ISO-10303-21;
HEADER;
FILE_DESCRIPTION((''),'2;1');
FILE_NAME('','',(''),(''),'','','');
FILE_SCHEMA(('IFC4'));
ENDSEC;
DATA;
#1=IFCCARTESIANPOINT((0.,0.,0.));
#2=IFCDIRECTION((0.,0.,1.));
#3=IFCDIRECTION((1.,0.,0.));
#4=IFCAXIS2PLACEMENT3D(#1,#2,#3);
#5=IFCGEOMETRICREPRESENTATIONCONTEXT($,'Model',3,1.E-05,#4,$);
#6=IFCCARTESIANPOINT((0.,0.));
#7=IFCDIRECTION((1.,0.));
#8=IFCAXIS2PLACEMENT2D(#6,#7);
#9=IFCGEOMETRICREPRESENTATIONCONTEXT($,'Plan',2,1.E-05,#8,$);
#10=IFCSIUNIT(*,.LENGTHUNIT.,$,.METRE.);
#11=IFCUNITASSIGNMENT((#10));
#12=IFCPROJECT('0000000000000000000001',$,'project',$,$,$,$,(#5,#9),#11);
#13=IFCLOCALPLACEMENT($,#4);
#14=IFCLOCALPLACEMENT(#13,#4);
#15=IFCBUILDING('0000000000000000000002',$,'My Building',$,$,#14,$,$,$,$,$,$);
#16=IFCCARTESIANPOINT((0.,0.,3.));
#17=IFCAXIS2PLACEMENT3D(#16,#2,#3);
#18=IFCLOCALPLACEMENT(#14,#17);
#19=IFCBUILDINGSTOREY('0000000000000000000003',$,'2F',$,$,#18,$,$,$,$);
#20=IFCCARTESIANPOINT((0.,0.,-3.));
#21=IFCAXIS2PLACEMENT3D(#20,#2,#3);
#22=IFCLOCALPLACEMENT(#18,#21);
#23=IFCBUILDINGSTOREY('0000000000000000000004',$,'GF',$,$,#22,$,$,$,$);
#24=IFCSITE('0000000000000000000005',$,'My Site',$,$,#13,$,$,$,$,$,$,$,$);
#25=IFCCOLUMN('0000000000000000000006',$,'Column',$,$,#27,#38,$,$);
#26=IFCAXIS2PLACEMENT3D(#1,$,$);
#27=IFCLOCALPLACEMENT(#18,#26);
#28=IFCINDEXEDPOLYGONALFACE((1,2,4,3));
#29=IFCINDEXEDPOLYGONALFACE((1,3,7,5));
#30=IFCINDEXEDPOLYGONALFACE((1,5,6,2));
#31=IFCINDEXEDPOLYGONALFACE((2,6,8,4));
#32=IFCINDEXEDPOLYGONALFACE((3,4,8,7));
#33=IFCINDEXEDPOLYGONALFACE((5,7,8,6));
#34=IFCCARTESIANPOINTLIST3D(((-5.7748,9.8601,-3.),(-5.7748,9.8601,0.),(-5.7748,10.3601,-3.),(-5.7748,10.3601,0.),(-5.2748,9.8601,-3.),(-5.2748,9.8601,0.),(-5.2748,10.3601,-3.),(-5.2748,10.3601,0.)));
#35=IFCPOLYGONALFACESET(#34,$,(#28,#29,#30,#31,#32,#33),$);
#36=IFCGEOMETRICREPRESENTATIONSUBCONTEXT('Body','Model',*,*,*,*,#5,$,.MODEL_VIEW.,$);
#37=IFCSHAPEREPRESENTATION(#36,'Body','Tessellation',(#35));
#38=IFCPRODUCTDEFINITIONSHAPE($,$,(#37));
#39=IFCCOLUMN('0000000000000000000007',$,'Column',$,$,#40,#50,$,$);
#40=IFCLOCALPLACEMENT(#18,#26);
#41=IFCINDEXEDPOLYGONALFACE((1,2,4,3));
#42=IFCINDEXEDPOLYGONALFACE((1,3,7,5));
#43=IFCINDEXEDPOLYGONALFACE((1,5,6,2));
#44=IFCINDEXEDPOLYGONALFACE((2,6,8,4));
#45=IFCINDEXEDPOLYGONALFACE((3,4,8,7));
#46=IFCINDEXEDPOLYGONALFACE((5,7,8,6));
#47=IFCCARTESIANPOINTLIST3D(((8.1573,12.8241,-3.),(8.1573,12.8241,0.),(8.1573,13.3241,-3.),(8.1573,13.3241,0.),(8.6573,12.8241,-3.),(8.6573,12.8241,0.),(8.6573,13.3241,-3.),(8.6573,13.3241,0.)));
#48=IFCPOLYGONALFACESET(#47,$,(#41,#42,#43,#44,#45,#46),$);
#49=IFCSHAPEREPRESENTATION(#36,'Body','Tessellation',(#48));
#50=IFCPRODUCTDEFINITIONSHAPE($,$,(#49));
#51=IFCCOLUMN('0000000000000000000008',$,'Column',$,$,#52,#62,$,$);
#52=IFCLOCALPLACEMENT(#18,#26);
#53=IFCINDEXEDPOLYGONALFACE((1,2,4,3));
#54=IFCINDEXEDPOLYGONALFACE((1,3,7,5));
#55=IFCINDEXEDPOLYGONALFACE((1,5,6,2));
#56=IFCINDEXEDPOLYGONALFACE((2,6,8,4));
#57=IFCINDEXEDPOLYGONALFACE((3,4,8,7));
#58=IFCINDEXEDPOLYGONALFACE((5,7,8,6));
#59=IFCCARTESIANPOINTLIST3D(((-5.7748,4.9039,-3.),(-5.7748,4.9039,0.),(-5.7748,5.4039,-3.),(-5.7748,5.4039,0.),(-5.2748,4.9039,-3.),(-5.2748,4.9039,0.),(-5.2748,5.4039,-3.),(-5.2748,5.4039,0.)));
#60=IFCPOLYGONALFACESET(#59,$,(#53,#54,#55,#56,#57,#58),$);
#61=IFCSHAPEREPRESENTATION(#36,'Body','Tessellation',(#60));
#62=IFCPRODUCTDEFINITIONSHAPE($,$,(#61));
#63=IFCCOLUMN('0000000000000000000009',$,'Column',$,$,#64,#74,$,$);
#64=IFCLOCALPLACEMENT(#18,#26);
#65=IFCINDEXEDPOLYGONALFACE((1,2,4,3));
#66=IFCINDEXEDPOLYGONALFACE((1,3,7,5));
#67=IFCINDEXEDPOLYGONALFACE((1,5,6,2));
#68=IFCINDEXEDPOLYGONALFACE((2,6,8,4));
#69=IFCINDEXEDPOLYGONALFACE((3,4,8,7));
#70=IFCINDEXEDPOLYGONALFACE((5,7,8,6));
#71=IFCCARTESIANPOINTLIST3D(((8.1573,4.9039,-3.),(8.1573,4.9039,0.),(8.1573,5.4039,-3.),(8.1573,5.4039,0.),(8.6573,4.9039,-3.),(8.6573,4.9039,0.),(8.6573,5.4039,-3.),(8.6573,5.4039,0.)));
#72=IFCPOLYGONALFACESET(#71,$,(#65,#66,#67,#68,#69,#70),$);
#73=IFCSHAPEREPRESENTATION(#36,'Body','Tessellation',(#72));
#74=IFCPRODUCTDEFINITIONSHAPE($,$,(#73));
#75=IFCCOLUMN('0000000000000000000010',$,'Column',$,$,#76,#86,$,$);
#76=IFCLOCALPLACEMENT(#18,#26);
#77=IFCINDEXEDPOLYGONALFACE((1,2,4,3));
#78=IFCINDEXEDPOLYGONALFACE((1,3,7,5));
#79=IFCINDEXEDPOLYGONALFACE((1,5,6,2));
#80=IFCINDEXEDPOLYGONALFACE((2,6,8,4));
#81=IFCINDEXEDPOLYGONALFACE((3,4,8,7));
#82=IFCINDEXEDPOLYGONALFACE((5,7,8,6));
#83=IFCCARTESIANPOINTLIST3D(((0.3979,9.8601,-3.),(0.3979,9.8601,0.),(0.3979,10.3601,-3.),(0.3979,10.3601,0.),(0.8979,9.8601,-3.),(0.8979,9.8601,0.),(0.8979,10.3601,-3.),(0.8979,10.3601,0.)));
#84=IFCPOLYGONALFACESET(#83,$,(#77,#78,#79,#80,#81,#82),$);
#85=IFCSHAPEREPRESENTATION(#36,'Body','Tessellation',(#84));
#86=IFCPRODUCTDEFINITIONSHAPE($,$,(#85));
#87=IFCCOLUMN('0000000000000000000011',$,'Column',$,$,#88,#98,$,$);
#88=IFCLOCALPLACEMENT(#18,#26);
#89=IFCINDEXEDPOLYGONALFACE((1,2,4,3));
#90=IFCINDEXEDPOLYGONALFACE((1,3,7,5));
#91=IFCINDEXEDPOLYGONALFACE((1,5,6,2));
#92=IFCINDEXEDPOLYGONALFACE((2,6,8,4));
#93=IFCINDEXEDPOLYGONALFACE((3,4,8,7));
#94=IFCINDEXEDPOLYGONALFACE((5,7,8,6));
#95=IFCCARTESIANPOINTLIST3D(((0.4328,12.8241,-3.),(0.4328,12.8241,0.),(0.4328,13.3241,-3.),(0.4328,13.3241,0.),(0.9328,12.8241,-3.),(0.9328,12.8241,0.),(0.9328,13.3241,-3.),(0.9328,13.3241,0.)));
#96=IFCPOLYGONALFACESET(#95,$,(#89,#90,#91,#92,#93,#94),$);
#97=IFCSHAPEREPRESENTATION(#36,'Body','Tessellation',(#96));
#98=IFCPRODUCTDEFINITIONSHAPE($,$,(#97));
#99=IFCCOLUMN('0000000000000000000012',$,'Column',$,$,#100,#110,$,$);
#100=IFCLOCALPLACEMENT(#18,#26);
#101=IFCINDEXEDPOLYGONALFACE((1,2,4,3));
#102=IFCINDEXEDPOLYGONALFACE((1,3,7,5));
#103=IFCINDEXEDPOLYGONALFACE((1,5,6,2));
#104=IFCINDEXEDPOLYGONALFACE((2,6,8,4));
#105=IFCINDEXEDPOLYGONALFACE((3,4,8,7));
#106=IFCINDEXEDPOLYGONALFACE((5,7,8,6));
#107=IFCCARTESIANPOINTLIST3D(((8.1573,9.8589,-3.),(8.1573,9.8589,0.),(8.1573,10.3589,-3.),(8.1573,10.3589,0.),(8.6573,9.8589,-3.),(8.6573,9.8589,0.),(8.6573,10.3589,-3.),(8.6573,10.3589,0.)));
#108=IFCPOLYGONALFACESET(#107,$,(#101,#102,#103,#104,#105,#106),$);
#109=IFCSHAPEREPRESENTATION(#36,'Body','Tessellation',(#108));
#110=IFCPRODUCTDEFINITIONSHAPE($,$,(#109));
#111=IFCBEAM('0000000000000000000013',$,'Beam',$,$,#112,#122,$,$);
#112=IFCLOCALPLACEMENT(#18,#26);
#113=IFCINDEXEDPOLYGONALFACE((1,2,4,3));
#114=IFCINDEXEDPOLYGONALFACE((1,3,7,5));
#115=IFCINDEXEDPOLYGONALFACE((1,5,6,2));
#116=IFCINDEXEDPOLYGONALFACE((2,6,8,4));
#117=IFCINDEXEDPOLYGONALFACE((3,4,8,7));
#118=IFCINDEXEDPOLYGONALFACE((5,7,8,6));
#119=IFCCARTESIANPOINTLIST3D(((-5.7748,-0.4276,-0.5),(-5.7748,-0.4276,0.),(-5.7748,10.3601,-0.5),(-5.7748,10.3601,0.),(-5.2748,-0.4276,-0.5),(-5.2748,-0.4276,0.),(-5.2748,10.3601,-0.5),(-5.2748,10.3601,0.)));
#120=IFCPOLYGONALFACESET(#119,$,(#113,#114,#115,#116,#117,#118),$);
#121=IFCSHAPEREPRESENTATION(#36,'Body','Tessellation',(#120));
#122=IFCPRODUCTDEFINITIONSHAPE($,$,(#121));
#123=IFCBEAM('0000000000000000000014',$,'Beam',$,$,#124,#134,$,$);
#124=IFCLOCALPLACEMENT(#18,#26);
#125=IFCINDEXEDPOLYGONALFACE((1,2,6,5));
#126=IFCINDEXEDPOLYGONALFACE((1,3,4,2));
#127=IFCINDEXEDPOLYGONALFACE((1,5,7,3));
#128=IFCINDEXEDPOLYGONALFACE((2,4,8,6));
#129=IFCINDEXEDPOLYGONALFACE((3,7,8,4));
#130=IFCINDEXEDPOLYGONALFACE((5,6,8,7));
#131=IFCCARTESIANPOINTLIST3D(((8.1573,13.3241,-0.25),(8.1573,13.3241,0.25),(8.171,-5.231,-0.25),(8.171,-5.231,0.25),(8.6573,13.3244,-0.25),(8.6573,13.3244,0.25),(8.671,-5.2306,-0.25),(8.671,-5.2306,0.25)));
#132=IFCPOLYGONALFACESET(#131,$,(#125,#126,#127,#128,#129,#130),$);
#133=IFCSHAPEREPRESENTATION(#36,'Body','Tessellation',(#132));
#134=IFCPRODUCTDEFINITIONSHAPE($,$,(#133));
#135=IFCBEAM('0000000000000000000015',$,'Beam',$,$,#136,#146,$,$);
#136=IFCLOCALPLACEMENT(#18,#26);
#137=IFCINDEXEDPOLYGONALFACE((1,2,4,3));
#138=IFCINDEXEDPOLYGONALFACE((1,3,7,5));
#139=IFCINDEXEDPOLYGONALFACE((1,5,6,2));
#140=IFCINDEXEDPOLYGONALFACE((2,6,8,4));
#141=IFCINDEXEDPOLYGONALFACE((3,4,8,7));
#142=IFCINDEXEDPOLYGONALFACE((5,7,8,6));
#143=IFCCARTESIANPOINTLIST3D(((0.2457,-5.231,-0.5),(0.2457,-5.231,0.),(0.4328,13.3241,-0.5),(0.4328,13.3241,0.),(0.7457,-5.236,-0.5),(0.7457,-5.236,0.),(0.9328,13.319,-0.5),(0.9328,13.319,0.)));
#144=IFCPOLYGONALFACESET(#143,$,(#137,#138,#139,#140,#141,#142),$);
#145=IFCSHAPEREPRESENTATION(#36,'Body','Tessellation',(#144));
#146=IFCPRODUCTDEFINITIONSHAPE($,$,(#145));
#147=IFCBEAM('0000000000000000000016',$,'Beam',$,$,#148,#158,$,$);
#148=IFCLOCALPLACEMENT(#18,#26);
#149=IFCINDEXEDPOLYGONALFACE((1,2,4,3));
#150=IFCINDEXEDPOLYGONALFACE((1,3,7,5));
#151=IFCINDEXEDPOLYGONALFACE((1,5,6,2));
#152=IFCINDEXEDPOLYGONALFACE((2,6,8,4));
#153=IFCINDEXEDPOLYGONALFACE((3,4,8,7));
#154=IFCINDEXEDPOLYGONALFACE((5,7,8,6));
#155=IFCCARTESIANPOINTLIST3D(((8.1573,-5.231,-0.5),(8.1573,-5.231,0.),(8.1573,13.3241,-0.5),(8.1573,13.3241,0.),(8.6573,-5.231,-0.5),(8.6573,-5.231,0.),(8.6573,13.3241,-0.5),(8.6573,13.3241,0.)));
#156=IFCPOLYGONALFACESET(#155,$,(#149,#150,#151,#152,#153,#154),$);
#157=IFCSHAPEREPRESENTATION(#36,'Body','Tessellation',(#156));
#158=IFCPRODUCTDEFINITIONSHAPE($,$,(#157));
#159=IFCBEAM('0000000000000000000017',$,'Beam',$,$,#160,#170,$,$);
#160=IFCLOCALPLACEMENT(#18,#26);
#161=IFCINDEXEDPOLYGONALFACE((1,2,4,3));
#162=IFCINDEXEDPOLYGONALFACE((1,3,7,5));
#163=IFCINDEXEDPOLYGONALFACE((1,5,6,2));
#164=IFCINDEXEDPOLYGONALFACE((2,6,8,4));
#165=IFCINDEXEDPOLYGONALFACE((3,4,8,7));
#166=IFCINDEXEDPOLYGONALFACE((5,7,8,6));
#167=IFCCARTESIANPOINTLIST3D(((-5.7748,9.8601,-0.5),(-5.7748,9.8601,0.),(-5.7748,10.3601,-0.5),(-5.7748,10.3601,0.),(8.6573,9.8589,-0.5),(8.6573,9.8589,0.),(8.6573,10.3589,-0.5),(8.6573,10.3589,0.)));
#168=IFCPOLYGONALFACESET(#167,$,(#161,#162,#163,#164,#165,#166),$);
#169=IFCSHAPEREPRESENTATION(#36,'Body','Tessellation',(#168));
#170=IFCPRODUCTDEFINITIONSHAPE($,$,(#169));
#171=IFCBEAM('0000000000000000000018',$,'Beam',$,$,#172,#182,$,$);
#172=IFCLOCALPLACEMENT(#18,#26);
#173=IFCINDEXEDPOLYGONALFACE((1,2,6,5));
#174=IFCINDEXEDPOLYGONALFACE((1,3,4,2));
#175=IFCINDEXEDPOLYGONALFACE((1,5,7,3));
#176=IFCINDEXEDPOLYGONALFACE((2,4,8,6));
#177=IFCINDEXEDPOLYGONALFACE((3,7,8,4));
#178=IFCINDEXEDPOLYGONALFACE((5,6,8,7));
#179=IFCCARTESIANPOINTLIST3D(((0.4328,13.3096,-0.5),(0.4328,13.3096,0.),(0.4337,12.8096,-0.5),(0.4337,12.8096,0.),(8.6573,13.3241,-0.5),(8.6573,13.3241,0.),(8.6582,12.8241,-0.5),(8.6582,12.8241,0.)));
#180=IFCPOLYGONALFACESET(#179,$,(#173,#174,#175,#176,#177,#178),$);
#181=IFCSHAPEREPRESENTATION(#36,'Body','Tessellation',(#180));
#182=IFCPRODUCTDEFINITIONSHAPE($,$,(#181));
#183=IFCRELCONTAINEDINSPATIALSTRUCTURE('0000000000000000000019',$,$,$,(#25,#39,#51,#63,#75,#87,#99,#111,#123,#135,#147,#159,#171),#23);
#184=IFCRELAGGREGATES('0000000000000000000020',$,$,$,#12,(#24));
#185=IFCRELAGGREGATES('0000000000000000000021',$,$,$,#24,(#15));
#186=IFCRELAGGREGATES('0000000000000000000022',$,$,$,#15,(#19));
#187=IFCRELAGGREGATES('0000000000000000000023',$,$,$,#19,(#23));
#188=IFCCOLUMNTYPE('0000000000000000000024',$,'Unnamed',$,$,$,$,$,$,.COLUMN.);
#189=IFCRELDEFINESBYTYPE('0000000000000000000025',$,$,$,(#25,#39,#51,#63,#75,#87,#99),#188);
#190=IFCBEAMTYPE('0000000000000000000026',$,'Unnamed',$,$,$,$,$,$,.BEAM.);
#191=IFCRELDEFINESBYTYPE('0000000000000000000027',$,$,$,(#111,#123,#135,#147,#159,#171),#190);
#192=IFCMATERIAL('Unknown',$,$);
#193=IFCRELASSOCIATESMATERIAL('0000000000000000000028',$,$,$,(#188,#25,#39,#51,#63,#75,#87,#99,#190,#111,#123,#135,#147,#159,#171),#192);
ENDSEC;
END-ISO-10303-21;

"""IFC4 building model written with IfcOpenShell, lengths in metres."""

from ifc_helpers import new_model, si_unit, frame, origin_with_axes, origin_2d_with_axis, place, context, subcontext, project, spatial, rectangle, extrude, material, material_profile, profile_set, profile_usage, type_object, element, save


model = new_model("IFC4")

# Units and contexts
model_context = context("Model", 3, precision=1e-05, world=origin_with_axes())
plan_context = context("Plan", 2, precision=1e-05, world=origin_2d_with_axis())
body_context_1 = subcontext(model_context, "Body", "Model", "MODEL_VIEW")
ifc_project = project(units=[si_unit("LENGTHUNIT", "METRE")], contexts=[model_context, plan_context])

# Site, building, storeys
site_placement = place(None, origin_with_axes())
site = spatial("IfcSite", under=ifc_project, at=site_placement, Name="My Site")
building_placement = place(site_placement, origin_with_axes())
building = spatial("IfcBuilding", under=site, at=building_placement, Name="My Building")
storey_1_placement = place(building_placement, frame((0.0, 0.0, 3.0), z_axis=(0.0, 0.0, 1.0), x_axis=(1.0, 0.0, 0.0)))
storey_1 = spatial("IfcBuildingStorey", under=building, at=storey_1_placement, Name="2F")
storey_2_placement = place(storey_1_placement, frame((0.0, 0.0, -3.0), z_axis=(0.0, 0.0, 1.0), x_axis=(1.0, 0.0, 0.0)))
storey_2 = spatial("IfcBuildingStorey", under=storey_1, at=storey_2_placement, Name="GF")

# Columns
ifc_material = material(Name="Unknown")
ifc_material_profile_1 = material_profile(ifc_material, rectangle(XDim=0.5, YDim=0.5))
ifc_profile_set_1 = profile_set([ifc_material_profile_1])
ifc_profile_usage_1 = profile_usage(ifc_profile_set_1, cardinal=5)
column_type = type_object("IfcColumnType", Name="Unnamed", PredefinedType="COLUMN", material=ifc_profile_set_1)
column_1_placement = place(storey_2_placement, frame((-5.5248, 10.1101, 0.0), z_axis=(0.0, 0.0, 1.0), x_axis=(1.0, 0.0, 0.0)))
element("IfcColumn", 1, at=column_1_placement, inside=storey_2, type_object=column_type, material=ifc_profile_usage_1, Name="Column", context=body_context_1, shape_type="SweptSolid", body=[
    extrude(rectangle(XDim=0.5, YDim=0.5), origin_with_axes(), (0.0, 0.0, 1.0), 3.0),
])
ifc_profile_usage_2 = profile_usage(ifc_profile_set_1, cardinal=5)
column_2_placement = place(storey_2_placement, frame((8.4073, 13.0741, 0.0), z_axis=(0.0, 0.0, 1.0), x_axis=(1.0, 0.0, 0.0)))
element("IfcColumn", 2, at=column_2_placement, inside=storey_2, type_object=column_type, material=ifc_profile_usage_2, Name="Column", context=body_context_1, shape_type="SweptSolid", body=[
    extrude(rectangle(XDim=0.5, YDim=0.5), origin_with_axes(), (0.0, 0.0, 1.0), 3.0),
])
ifc_profile_usage_3 = profile_usage(ifc_profile_set_1, cardinal=5)
column_3_placement = place(storey_2_placement, frame((-5.5248, 5.1539, 0.0), z_axis=(0.0, 0.0, 1.0), x_axis=(1.0, 0.0, 0.0)))
element("IfcColumn", 3, at=column_3_placement, inside=storey_2, type_object=column_type, material=ifc_profile_usage_3, Name="Column", context=body_context_1, shape_type="SweptSolid", body=[
    extrude(rectangle(XDim=0.5, YDim=0.5), origin_with_axes(), (0.0, 0.0, 1.0), 3.0),
])
ifc_profile_usage_4 = profile_usage(ifc_profile_set_1, cardinal=5)
column_4_placement = place(storey_2_placement, frame((8.4073, 5.1539, 0.0), z_axis=(0.0, 0.0, 1.0), x_axis=(1.0, 0.0, 0.0)))
element("IfcColumn", 4, at=column_4_placement, inside=storey_2, type_object=column_type, material=ifc_profile_usage_4, Name="Column", context=body_context_1, shape_type="SweptSolid", body=[
    extrude(rectangle(XDim=0.5, YDim=0.5), origin_with_axes(), (0.0, 0.0, 1.0), 3.0),
])
ifc_profile_usage_5 = profile_usage(ifc_profile_set_1, cardinal=5)
column_5_placement = place(storey_2_placement, frame((0.6479, 10.1101, 0.0), z_axis=(0.0, 0.0, 1.0), x_axis=(1.0, 0.0, 0.0)))
element("IfcColumn", 5, at=column_5_placement, inside=storey_2, type_object=column_type, material=ifc_profile_usage_5, Name="Column", context=body_context_1, shape_type="SweptSolid", body=[
    extrude(rectangle(XDim=0.5, YDim=0.5), origin_with_axes(), (0.0, 0.0, 1.0), 3.0),
])
ifc_profile_usage_6 = profile_usage(ifc_profile_set_1, cardinal=5)
column_6_placement = place(storey_2_placement, frame((0.6828, 13.0741, 0.0), z_axis=(0.0, 0.0, 1.0), x_axis=(1.0, 0.0, 0.0)))
element("IfcColumn", 6, at=column_6_placement, inside=storey_2, type_object=column_type, material=ifc_profile_usage_6, Name="Column", context=body_context_1, shape_type="SweptSolid", body=[
    extrude(rectangle(XDim=0.5, YDim=0.5), origin_with_axes(), (0.0, 0.0, 1.0), 3.0),
])
ifc_profile_usage_7 = profile_usage(ifc_profile_set_1, cardinal=5)
column_7_placement = place(storey_2_placement, frame((8.4073, 10.1089, 0.0), z_axis=(0.0, 0.0, 1.0), x_axis=(1.0, 0.0, 0.0)))
element("IfcColumn", 7, at=column_7_placement, inside=storey_2, type_object=column_type, material=ifc_profile_usage_7, Name="Column", context=body_context_1, shape_type="SweptSolid", body=[
    extrude(rectangle(XDim=0.5, YDim=0.5), origin_with_axes(), (0.0, 0.0, 1.0), 3.0),
])

# Beams
ifc_material_profile_2 = material_profile(ifc_material, rectangle(XDim=0.5, YDim=0.5))
ifc_profile_set_2 = profile_set([ifc_material_profile_2])
ifc_profile_usage_8 = profile_usage(ifc_profile_set_2, cardinal=6)
beam_type = type_object("IfcBeamType", Name="Unnamed", PredefinedType="BEAM", material=ifc_profile_set_2)
beam_1_placement = place(storey_2_placement, frame((-5.7748, 10.3601, 2.75), z_axis=(0.0, -1.0, 0.0), x_axis=(1.0, 0.0, 0.0)))
element("IfcBeam", 8, at=beam_1_placement, inside=storey_2, type_object=beam_type, material=ifc_profile_usage_8, Name="Beam", context=body_context_1, shape_type="SweptSolid", body=[
    extrude(rectangle(XDim=0.5, YDim=0.5), frame((0.25, 0.0, 0.0), z_axis=(0.0, 0.0, 1.0), x_axis=(1.0, 0.0, 0.0)), (0.0, 0.0, 1.0), 10.7877),
])
ifc_profile_usage_9 = profile_usage(ifc_profile_set_2, cardinal=6)
beam_2_placement = place(storey_2_placement, frame((8.1573, 13.3241, 3.0), z_axis=(0.000738, -1.0, 0.0), x_axis=(1.0, 0.000738, 0.0)))
element("IfcBeam", 9, at=beam_2_placement, inside=storey_2, type_object=beam_type, material=ifc_profile_usage_9, Name="Beam", context=body_context_1, shape_type="SweptSolid", body=[
    extrude(rectangle(XDim=0.5, YDim=0.5), frame((0.25, 0.0, 0.0), z_axis=(0.0, 0.0, 1.0), x_axis=(1.0, 0.0, 0.0)), (0.0, 0.0, 1.0), 18.555),
])
ifc_profile_usage_10 = profile_usage(ifc_profile_set_2, cardinal=6)
beam_3_placement = place(storey_2_placement, frame((0.4328, 13.3241, 2.75), z_axis=(-0.010085, -0.999949, 0.0), x_axis=(0.999949, -0.010085, 0.0)))
element("IfcBeam", 10, at=beam_3_placement, inside=storey_2, type_object=beam_type, material=ifc_profile_usage_10, Name="Beam", context=body_context_1, shape_type="SweptSolid", body=[
    extrude(rectangle(XDim=0.5, YDim=0.5), frame((0.25, 0.0, 0.0), z_axis=(0.0, 0.0, 1.0), x_axis=(1.0, 0.0, 0.0)), (0.0, 0.0, 1.0), 18.556),
])
ifc_profile_usage_11 = profile_usage(ifc_profile_set_2, cardinal=5)
beam_4_placement = place(storey_2_placement, frame((8.4073, 13.3241, 2.75), z_axis=(0.0, -1.0, 0.0), x_axis=(1.0, 0.0, 0.0)))
element("IfcBeam", 11, at=beam_4_placement, inside=storey_2, type_object=beam_type, material=ifc_profile_usage_11, Name="Beam", context=body_context_1, shape_type="SweptSolid", body=[
    extrude(rectangle(XDim=0.5, YDim=0.5), origin_with_axes(), (0.0, 0.0, 1.0), 18.555),
])
ifc_profile_usage_12 = profile_usage(ifc_profile_set_2, cardinal=9)
beam_5_placement = place(storey_2_placement, frame((-5.7748, 9.8601, 3.0), z_axis=(1.0, -0.000081, 0.0), x_axis=(0.000081, 1.0, 0.0)))
element("IfcBeam", 12, at=beam_5_placement, inside=storey_2, type_object=beam_type, material=ifc_profile_usage_12, Name="Beam", context=body_context_1, shape_type="SweptSolid", body=[
    extrude(rectangle(XDim=0.5, YDim=0.5), frame((0.25, -0.25, 0.0), z_axis=(0.0, 0.0, 1.0), x_axis=(1.0, 0.0, 0.0)), (0.0, 0.0, 1.0), 14.4321),
])
ifc_profile_usage_13 = profile_usage(ifc_profile_set_2, cardinal=9)
beam_6_placement = place(storey_2_placement, frame((8.6573, 13.3241, 3.0), z_axis=(-0.999998, -0.001763, 0.000001), x_axis=(0.001763, -0.999998, 0.000001)))
element("IfcBeam", 13, at=beam_6_placement, inside=storey_2, type_object=beam_type, material=ifc_profile_usage_13, Name="Beam", context=body_context_1, shape_type="SweptSolid", body=[
    extrude(rectangle(XDim=0.5, YDim=0.5), frame((0.25, -0.25, 0.0), z_axis=(0.0, 0.0, 1.0), x_axis=(1.0, 0.0, 0.0)), (0.0, 0.0, 1.0), 8.2244),
])

save(model, "model.ifc")
